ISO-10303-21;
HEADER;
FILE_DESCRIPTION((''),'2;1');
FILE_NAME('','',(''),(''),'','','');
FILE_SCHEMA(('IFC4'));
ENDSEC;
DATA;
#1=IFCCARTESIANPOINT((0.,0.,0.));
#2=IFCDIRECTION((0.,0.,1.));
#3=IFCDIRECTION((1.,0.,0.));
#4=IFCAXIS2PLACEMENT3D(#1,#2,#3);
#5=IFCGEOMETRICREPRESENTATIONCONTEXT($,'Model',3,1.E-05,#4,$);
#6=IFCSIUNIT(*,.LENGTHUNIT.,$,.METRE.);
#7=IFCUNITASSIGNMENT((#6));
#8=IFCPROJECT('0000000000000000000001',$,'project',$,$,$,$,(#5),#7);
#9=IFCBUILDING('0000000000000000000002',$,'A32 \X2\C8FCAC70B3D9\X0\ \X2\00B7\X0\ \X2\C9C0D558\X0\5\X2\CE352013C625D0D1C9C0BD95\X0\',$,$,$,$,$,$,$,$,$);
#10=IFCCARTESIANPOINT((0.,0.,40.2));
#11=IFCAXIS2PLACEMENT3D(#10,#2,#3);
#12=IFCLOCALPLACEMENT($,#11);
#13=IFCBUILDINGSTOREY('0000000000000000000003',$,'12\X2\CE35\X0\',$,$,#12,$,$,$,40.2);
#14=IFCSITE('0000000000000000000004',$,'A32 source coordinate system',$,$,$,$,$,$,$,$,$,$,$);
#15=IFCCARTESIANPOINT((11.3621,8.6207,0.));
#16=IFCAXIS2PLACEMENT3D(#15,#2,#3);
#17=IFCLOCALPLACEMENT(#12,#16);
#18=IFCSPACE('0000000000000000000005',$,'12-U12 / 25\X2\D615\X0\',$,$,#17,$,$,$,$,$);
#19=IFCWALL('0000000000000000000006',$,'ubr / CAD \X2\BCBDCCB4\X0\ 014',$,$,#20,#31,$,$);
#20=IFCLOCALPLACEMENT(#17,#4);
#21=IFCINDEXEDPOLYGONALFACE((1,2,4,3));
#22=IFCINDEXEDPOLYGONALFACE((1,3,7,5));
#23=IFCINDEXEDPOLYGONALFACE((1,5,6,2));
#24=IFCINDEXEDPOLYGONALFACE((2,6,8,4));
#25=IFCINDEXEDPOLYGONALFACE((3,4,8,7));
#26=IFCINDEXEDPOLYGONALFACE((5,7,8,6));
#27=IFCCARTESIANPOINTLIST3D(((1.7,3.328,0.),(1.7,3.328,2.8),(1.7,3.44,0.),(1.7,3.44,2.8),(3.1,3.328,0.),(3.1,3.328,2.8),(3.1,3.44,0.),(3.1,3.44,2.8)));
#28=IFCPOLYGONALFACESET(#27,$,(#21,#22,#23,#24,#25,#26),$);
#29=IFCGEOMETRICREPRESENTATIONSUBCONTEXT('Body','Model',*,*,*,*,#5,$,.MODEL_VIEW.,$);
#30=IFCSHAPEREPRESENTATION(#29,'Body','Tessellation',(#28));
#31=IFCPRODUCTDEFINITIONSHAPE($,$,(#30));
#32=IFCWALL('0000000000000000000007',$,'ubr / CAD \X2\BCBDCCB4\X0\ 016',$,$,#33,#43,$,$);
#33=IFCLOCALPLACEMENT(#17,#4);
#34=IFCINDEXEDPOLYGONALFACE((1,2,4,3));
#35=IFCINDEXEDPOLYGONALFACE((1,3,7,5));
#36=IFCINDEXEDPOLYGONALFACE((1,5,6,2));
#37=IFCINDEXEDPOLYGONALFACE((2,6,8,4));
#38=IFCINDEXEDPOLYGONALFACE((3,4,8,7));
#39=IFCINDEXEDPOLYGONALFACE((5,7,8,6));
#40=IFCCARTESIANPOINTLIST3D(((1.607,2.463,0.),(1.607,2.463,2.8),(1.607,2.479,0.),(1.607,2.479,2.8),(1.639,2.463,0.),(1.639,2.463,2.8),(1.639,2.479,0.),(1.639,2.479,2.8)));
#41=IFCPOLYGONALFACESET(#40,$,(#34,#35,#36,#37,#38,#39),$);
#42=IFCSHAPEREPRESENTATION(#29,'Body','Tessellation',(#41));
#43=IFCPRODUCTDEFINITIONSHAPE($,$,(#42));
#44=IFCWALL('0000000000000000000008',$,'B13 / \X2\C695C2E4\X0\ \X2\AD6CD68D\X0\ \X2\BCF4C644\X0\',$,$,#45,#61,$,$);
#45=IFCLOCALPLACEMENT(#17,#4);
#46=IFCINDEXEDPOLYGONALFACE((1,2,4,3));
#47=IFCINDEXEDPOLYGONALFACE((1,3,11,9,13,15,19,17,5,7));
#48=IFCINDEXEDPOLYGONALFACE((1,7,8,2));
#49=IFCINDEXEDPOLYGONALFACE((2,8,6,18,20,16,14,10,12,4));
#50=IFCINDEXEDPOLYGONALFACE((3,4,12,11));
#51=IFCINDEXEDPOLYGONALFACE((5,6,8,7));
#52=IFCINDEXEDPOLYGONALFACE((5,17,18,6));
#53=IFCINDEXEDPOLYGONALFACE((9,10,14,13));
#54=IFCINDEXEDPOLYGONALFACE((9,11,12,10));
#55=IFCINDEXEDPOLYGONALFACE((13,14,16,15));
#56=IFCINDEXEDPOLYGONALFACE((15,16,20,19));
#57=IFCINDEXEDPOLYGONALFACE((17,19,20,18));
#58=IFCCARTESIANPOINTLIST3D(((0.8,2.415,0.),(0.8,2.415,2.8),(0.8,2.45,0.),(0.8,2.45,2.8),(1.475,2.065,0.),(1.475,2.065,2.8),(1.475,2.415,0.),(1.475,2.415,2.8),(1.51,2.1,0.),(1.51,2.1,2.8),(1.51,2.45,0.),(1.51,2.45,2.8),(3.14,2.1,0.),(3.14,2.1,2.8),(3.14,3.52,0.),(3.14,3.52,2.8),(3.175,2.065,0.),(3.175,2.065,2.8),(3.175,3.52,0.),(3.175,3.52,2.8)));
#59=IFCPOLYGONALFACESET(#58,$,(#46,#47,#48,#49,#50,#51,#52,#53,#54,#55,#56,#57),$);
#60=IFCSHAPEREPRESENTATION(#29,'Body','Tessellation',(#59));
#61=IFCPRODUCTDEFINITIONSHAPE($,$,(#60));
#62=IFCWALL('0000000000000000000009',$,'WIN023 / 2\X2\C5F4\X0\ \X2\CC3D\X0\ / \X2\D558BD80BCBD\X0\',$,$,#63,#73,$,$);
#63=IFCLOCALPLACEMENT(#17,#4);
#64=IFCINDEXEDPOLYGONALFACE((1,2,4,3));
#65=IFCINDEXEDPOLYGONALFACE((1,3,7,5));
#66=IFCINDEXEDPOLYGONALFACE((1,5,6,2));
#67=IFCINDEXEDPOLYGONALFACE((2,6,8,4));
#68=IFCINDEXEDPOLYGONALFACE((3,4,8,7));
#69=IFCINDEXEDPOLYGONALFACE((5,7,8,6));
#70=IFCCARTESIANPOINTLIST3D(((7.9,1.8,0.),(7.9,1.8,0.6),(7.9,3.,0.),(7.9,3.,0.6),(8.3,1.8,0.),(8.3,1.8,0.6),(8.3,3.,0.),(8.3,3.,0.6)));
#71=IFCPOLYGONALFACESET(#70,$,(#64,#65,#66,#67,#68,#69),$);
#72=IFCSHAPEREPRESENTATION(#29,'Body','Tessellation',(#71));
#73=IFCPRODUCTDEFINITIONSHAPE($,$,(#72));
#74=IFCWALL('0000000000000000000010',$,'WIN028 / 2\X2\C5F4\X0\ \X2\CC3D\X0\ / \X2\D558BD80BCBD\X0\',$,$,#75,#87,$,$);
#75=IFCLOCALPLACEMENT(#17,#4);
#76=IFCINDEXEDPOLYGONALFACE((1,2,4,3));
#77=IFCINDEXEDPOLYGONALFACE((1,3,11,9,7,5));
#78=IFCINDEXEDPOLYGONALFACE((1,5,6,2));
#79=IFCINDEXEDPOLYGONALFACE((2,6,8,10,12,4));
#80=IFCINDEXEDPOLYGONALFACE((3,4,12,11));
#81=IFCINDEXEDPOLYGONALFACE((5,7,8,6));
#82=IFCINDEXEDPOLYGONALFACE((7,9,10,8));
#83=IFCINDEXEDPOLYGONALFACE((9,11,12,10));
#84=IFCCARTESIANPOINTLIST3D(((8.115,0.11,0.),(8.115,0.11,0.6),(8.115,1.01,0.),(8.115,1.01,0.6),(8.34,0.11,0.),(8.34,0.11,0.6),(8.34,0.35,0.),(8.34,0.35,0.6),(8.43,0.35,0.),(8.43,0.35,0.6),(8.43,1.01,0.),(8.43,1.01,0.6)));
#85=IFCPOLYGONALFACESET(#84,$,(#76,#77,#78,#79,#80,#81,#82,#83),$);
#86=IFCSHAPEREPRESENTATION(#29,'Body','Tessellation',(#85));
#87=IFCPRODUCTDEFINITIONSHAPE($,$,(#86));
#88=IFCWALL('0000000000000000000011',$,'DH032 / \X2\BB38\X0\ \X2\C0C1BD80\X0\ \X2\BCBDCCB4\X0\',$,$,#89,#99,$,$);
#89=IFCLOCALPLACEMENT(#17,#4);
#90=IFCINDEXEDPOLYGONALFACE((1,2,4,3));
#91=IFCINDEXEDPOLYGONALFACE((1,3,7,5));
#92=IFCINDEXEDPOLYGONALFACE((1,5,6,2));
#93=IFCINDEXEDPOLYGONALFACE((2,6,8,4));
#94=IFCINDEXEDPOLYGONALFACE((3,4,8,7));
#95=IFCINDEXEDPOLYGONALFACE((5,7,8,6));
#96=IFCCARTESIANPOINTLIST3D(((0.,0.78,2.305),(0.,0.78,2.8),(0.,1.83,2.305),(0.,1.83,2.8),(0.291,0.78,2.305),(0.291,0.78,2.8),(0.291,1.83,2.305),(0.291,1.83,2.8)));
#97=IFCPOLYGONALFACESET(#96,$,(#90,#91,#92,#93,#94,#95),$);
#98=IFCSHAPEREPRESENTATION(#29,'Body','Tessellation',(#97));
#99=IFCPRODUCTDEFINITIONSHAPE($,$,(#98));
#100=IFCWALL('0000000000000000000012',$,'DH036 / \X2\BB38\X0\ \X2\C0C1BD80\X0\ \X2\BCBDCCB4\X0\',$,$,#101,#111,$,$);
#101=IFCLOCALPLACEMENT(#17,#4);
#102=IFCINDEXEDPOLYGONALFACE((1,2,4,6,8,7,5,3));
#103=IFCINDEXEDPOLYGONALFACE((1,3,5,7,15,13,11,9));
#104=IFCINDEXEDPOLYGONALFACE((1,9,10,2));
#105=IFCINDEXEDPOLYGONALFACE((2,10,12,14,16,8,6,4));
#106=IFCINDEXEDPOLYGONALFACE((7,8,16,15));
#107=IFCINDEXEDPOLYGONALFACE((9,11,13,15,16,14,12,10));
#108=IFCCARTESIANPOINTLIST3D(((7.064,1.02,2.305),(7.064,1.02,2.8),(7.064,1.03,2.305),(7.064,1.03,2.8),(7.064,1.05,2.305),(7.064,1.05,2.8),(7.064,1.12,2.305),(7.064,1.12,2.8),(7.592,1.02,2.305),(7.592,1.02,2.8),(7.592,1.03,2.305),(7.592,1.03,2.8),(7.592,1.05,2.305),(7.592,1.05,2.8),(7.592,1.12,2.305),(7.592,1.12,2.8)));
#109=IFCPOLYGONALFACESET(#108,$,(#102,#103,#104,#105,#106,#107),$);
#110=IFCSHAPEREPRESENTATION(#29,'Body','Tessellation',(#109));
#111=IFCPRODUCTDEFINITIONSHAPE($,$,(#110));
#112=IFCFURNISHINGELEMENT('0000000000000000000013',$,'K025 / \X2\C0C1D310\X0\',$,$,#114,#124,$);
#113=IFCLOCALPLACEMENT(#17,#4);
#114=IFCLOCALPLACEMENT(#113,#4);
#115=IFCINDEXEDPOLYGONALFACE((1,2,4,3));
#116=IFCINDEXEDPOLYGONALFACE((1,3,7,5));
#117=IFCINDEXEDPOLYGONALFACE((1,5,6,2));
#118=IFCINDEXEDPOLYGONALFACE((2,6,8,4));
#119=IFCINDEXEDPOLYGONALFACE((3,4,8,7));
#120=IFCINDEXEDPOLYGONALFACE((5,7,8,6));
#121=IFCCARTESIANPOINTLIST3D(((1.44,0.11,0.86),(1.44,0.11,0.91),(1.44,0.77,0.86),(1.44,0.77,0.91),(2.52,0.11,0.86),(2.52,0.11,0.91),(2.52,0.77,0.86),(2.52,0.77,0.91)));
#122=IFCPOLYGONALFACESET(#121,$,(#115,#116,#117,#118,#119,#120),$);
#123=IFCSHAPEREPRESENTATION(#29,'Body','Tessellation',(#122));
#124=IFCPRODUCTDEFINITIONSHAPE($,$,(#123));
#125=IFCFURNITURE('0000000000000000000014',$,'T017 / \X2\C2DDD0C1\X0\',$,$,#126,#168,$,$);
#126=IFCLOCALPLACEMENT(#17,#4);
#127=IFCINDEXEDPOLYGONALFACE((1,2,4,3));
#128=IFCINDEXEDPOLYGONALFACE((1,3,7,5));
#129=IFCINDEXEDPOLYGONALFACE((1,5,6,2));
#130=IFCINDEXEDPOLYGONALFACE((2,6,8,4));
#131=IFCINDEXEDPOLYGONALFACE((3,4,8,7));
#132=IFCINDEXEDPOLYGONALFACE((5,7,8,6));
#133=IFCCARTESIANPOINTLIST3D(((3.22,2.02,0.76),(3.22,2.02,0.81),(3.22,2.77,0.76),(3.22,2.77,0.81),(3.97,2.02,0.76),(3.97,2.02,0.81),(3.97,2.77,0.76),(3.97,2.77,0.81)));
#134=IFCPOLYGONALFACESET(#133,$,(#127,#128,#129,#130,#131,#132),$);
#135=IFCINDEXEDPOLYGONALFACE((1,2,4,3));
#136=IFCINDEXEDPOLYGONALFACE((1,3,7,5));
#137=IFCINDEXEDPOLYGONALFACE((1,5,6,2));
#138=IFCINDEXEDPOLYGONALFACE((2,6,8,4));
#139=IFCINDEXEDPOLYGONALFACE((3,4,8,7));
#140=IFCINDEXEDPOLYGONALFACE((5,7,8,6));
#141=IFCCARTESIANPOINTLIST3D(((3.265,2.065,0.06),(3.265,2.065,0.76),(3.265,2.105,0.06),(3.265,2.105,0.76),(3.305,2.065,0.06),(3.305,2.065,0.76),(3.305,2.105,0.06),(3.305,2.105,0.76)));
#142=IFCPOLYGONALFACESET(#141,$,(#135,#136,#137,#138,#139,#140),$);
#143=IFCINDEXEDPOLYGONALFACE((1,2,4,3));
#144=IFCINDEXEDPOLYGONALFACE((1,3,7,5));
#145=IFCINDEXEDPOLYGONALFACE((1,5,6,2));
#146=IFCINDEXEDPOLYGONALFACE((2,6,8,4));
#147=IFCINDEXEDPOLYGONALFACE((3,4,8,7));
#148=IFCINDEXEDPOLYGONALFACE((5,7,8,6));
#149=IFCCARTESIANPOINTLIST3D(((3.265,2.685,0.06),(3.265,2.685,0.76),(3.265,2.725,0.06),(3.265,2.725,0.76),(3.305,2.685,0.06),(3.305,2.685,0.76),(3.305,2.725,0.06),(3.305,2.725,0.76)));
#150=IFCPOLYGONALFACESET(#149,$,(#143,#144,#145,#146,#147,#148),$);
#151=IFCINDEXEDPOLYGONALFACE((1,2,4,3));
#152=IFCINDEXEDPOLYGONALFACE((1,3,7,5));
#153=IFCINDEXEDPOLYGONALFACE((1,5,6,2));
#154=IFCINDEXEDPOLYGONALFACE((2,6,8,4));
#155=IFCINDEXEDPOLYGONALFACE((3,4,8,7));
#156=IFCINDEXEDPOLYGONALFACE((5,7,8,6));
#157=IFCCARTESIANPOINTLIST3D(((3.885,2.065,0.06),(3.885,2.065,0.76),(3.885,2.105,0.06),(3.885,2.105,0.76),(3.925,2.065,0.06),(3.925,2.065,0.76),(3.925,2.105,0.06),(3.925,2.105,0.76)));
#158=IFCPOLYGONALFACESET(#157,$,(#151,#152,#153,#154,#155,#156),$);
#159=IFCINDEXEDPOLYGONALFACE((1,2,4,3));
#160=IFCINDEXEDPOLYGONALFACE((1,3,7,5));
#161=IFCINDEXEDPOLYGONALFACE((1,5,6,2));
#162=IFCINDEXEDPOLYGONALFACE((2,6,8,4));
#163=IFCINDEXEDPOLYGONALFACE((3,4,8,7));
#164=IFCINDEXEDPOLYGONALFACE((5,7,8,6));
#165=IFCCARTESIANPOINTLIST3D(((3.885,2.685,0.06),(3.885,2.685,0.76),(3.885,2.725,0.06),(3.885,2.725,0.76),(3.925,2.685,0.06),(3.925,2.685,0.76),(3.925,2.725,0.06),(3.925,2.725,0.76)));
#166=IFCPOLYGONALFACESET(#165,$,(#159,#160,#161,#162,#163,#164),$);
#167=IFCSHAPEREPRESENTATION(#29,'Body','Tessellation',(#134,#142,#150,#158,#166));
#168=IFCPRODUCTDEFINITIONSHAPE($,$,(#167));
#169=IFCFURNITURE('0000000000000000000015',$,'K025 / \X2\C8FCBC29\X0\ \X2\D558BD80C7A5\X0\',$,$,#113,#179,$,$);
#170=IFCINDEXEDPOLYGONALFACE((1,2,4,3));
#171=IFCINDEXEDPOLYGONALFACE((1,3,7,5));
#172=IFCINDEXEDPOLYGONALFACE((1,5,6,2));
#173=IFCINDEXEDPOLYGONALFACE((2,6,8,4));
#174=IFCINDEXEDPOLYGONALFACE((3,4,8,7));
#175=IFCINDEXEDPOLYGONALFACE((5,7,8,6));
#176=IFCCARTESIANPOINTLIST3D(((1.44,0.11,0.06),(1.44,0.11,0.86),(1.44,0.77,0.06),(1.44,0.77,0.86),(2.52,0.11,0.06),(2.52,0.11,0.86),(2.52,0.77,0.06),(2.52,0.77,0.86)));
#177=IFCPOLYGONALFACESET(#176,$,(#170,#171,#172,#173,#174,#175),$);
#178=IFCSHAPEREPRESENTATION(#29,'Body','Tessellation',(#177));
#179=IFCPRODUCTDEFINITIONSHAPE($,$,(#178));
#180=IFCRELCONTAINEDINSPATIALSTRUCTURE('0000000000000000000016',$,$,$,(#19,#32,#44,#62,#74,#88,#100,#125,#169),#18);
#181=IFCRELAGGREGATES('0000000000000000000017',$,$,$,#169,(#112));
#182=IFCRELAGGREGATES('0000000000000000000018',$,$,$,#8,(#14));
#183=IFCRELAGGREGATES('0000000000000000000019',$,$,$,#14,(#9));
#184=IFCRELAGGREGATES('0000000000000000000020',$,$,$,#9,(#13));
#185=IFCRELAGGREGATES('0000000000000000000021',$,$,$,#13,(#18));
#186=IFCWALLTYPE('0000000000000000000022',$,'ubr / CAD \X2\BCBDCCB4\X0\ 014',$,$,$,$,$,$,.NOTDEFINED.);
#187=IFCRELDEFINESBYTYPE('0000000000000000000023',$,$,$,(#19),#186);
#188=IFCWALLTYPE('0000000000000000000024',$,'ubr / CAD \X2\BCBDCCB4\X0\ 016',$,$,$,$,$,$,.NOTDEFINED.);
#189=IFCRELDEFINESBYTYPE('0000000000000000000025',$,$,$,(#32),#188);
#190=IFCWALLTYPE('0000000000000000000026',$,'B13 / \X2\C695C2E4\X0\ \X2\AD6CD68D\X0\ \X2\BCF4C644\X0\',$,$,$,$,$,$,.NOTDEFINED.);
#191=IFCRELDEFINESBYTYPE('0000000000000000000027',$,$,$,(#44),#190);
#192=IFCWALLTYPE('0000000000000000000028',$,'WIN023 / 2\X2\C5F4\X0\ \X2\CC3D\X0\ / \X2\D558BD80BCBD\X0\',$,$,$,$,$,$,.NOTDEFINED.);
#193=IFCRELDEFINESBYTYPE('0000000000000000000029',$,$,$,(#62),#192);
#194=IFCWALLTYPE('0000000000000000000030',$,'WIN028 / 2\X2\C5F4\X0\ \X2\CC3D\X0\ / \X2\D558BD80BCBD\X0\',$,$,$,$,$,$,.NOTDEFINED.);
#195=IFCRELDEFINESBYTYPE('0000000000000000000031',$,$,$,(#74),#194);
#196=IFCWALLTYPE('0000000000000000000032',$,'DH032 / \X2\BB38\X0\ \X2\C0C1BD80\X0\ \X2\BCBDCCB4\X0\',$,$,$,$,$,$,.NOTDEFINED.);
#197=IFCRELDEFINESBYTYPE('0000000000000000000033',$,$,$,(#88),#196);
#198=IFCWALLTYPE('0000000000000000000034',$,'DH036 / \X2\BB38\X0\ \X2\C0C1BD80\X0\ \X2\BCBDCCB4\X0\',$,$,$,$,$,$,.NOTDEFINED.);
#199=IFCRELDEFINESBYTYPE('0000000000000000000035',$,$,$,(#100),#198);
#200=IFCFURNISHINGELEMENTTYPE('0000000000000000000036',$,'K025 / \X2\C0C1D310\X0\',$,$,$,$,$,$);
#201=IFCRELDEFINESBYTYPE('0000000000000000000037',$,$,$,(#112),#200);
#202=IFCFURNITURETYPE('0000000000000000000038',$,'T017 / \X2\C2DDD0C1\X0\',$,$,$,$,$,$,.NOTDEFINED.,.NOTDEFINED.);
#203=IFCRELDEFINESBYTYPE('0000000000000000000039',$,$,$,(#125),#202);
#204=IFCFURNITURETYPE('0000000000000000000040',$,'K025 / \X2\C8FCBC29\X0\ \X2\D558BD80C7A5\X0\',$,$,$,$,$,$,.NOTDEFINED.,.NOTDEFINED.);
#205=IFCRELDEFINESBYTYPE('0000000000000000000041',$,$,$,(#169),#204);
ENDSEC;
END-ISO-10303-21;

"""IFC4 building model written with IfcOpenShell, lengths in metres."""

from ifc_helpers import new_model, si_unit, frame, origin, origin_with_axes, place, context, subcontext, project, spatial, polyline, outline, extrude, source, transform, mapped, type_object, type_shapes, element, aggregate, save


model = new_model("IFC4")

# Units and contexts
model_context = context("Model", 3, precision=1e-05, world=origin_with_axes())
body_context = subcontext(model_context, "Body", "Model", "MODEL_VIEW")
ifc_project = project(units=[si_unit("LENGTHUNIT", "METRE")], contexts=[model_context])

# Site, building, storey, space
site = spatial("IfcSite", under=ifc_project, Name="A32 source coordinate system")
building = spatial("IfcBuilding", under=site, Name="A32 주거동 · 지하5층–옥탑지붕")
storey_placement = place(None, frame((0.0, 0.0, 40.2), z_axis=(0.0, 0.0, 1.0), x_axis=(1.0, 0.0, 0.0)))
storey = spatial("IfcBuildingStorey", under=building, at=storey_placement, Name="12층", Elevation=40.2)
space_1_placement = place(storey_placement, frame((11.3621, 8.6207, 0.0), z_axis=(0.0, 0.0, 1.0), x_axis=(1.0, 0.0, 0.0)))
space_1 = spatial("IfcSpace", under=storey, at=space_1_placement, Name="12-U12 / 25형")

# Walls
wall_type_1 = type_object("IfcWallType", Name="ubr / CAD 벽체 014", PredefinedType="NOTDEFINED")
shared_shape_1 = source(origin(), body_context, "Body", "SweptSolid", [
    extrude(outline(polyline([(3.1, 3.44), (3.1, 3.328), (1.7, 3.328), (1.7, 3.44), (3.1, 3.44)])), origin(), (0.0, 0.0, 1.0), 2.8),
])
type_shapes(wall_type_1, [shared_shape_1])
wall_1_placement = place(space_1_placement, origin_with_axes())
element("IfcWall", 1, at=wall_1_placement, inside=space_1, type_object=wall_type_1, Name="ubr / CAD 벽체 014", context=body_context, shape_type="MappedRepresentation", body=[
    mapped(shared_shape_1, transform((0.0, 0.0, 0.0), scale=1.0)),
])
wall_type_2 = type_object("IfcWallType", Name="ubr / CAD 벽체 016", PredefinedType="NOTDEFINED")
shared_shape_2 = source(origin(), body_context, "Body", "SweptSolid", [
    extrude(outline(polyline([(1.639, 2.479), (1.639, 2.463), (1.607, 2.463), (1.607, 2.479), (1.639, 2.479)])), origin(), (0.0, 0.0, 1.0), 2.8),
])
type_shapes(wall_type_2, [shared_shape_2])
wall_2_placement = place(space_1_placement, origin_with_axes())
element("IfcWall", 2, at=wall_2_placement, inside=space_1, type_object=wall_type_2, Name="ubr / CAD 벽체 016", context=body_context, shape_type="MappedRepresentation", body=[
    mapped(shared_shape_2, transform((0.0, 0.0, 0.0), scale=1.0)),
])
wall_type_3 = type_object("IfcWallType", Name="B13 / 욕실 구획 보완", PredefinedType="NOTDEFINED")
shared_shape_3 = source(origin(), body_context, "Body", "SweptSolid", [
    extrude(outline(polyline([(0.8, 2.45), (1.51, 2.45), (1.51, 2.1), (3.14, 2.1), (3.14, 3.52), (3.175, 3.52), (3.175, 2.065), (1.475, 2.065), (1.475, 2.415), (0.8, 2.415), (0.8, 2.45)])), origin(), (0.0, 0.0, 1.0), 2.8),
])
type_shapes(wall_type_3, [shared_shape_3])
wall_3_placement = place(space_1_placement, origin_with_axes())
element("IfcWall", 3, at=wall_3_placement, inside=space_1, type_object=wall_type_3, Name="B13 / 욕실 구획 보완", context=body_context, shape_type="MappedRepresentation", body=[
    mapped(shared_shape_3, transform((0.0, 0.0, 0.0), scale=1.0)),
])
wall_type_4 = type_object("IfcWallType", Name="WIN023 / 2열 창 / 하부벽", PredefinedType="NOTDEFINED")
shared_shape_4 = source(origin(), body_context, "Body", "SweptSolid", [
    extrude(outline(polyline([(7.9, 1.8), (7.9, 3.0), (8.3, 3.0), (8.3, 1.8), (7.9, 1.8)])), origin(), (0.0, 0.0, 1.0), 0.6),
])
type_shapes(wall_type_4, [shared_shape_4])
wall_4_placement = place(space_1_placement, origin_with_axes())
element("IfcWall", 4, at=wall_4_placement, inside=space_1, type_object=wall_type_4, Name="WIN023 / 2열 창 / 하부벽", context=body_context, shape_type="MappedRepresentation", body=[
    mapped(shared_shape_4, transform((0.0, 0.0, 0.0), scale=1.0)),
])
wall_type_5 = type_object("IfcWallType", Name="WIN028 / 2열 창 / 하부벽", PredefinedType="NOTDEFINED")
shared_shape_5 = source(origin(), body_context, "Body", "SweptSolid", [
    extrude(outline(polyline([(8.34, 0.35), (8.34, 0.11), (8.115, 0.11), (8.115, 1.01), (8.43, 1.01), (8.43, 0.35), (8.34, 0.35)])), origin(), (0.0, 0.0, 1.0), 0.6),
])
type_shapes(wall_type_5, [shared_shape_5])
wall_5_placement = place(space_1_placement, origin_with_axes())
element("IfcWall", 5, at=wall_5_placement, inside=space_1, type_object=wall_type_5, Name="WIN028 / 2열 창 / 하부벽", context=body_context, shape_type="MappedRepresentation", body=[
    mapped(shared_shape_5, transform((0.0, 0.0, 0.0), scale=1.0)),
])
wall_type_6 = type_object("IfcWallType", Name="DH032 / 문 상부 벽체", PredefinedType="NOTDEFINED")
shared_shape_6 = source(origin(), body_context, "Body", "SweptSolid", [
    extrude(outline(polyline([(0.0, 1.83), (0.291, 1.83), (0.291, 0.78), (0.0, 0.78), (0.0, 1.83)])), frame((0.0, 0.0, 2.305)), (0.0, 0.0, 1.0), 0.495),
])
type_shapes(wall_type_6, [shared_shape_6])
wall_6_placement = place(space_1_placement, origin_with_axes())
element("IfcWall", 6, at=wall_6_placement, inside=space_1, type_object=wall_type_6, Name="DH032 / 문 상부 벽체", context=body_context, shape_type="MappedRepresentation", body=[
    mapped(shared_shape_6, transform((0.0, 0.0, 0.0), scale=1.0)),
])
wall_type_7 = type_object("IfcWallType", Name="DH036 / 문 상부 벽체", PredefinedType="NOTDEFINED")
shared_shape_7 = source(origin(), body_context, "Body", "SweptSolid", [
    extrude(outline(polyline([(7.064, 1.03), (7.064, 1.05), (7.064, 1.12), (7.592, 1.12), (7.592, 1.05), (7.592, 1.03), (7.592, 1.02), (7.064, 1.02), (7.064, 1.03)])), frame((0.0, 0.0, 2.305)), (0.0, 0.0, 1.0), 0.495),
])
type_shapes(wall_type_7, [shared_shape_7])
wall_7_placement = place(space_1_placement, origin_with_axes())
element("IfcWall", 7, at=wall_7_placement, inside=space_1, type_object=wall_type_7, Name="DH036 / 문 상부 벽체", context=body_context, shape_type="MappedRepresentation", body=[
    mapped(shared_shape_7, transform((0.0, 0.0, 0.0), scale=1.0)),
])

# Furnishing element
furnishing_element_type_1 = type_object("IfcFurnishingElementType", Name="K025 / 상판")
shared_shape_8 = source(origin(), body_context, "Body", "SweptSolid", [
    extrude(outline(polyline([(2.52, 0.77), (2.52, 0.11), (1.44, 0.11), (1.44, 0.77), (2.52, 0.77)])), frame((0.0, 0.0, 0.86)), (0.0, 0.0, 1.0), 0.05),
])
type_shapes(furnishing_element_type_1, [shared_shape_8])
furniture_1_placement = place(space_1_placement, origin_with_axes())
furnishing_1_placement = place(furniture_1_placement, origin_with_axes())
furnishing_1 = element("IfcFurnishingElement", 8, at=furnishing_1_placement, type_object=furnishing_element_type_1, Name="K025 / 상판", context=body_context, shape_type="MappedRepresentation", body=[
    mapped(shared_shape_8, transform((0.0, 0.0, 0.0), scale=1.0)),
])

# Furniture
furniture_type_1 = type_object("IfcFurnitureType", Name="T017 / 식탁", AssemblyPlace="NOTDEFINED", PredefinedType="NOTDEFINED")
shared_shape_9 = source(origin(), body_context, "Body", "SweptSolid", [
    extrude(outline(polyline([(3.97, 2.02), (3.22, 2.02), (3.22, 2.77), (3.97, 2.77), (3.97, 2.02)])), frame((0.0, 0.0, 0.76)), (0.0, 0.0, 1.0), 0.05),
    extrude(outline(polyline([(3.265, 2.065), (3.265, 2.105), (3.305, 2.105), (3.305, 2.065), (3.265, 2.065)])), frame((0.0, 0.0, 0.06)), (0.0, 0.0, 1.0), 0.7),
    extrude(outline(polyline([(3.265, 2.685), (3.265, 2.725), (3.305, 2.725), (3.305, 2.685), (3.265, 2.685)])), frame((0.0, 0.0, 0.06)), (0.0, 0.0, 1.0), 0.7),
    extrude(outline(polyline([(3.885, 2.065), (3.885, 2.105), (3.925, 2.105), (3.925, 2.065), (3.885, 2.065)])), frame((0.0, 0.0, 0.06)), (0.0, 0.0, 1.0), 0.7),
    extrude(outline(polyline([(3.885, 2.685), (3.885, 2.725), (3.925, 2.725), (3.925, 2.685), (3.885, 2.685)])), frame((0.0, 0.0, 0.06)), (0.0, 0.0, 1.0), 0.7),
])
type_shapes(furniture_type_1, [shared_shape_9])
furniture_2_placement = place(space_1_placement, origin_with_axes())
element("IfcFurniture", 9, at=furniture_2_placement, inside=space_1, type_object=furniture_type_1, Name="T017 / 식탁", context=body_context, shape_type="MappedRepresentation", body=[
    mapped(shared_shape_9, transform((0.0, 0.0, 0.0), scale=1.0)),
])
furniture_type_2 = type_object("IfcFurnitureType", Name="K025 / 주방 하부장", AssemblyPlace="NOTDEFINED", PredefinedType="NOTDEFINED")
shared_shape_10 = source(origin(), body_context, "Body", "SweptSolid", [
    extrude(outline(polyline([(1.44, 0.77), (2.52, 0.77), (2.52, 0.11), (1.44, 0.11), (1.44, 0.77)])), frame((0.0, 0.0, 0.06)), (0.0, 0.0, 1.0), 0.8),
])
type_shapes(furniture_type_2, [shared_shape_10])
furniture_1 = element("IfcFurniture", 10, at=furniture_1_placement, inside=space_1, type_object=furniture_type_2, Name="K025 / 주방 하부장", context=body_context, shape_type="MappedRepresentation", body=[
    mapped(shared_shape_10, transform((0.0, 0.0, 0.0), scale=1.0)),
])
aggregate(furniture_1, [furnishing_1])

save(model, "model.ifc")
